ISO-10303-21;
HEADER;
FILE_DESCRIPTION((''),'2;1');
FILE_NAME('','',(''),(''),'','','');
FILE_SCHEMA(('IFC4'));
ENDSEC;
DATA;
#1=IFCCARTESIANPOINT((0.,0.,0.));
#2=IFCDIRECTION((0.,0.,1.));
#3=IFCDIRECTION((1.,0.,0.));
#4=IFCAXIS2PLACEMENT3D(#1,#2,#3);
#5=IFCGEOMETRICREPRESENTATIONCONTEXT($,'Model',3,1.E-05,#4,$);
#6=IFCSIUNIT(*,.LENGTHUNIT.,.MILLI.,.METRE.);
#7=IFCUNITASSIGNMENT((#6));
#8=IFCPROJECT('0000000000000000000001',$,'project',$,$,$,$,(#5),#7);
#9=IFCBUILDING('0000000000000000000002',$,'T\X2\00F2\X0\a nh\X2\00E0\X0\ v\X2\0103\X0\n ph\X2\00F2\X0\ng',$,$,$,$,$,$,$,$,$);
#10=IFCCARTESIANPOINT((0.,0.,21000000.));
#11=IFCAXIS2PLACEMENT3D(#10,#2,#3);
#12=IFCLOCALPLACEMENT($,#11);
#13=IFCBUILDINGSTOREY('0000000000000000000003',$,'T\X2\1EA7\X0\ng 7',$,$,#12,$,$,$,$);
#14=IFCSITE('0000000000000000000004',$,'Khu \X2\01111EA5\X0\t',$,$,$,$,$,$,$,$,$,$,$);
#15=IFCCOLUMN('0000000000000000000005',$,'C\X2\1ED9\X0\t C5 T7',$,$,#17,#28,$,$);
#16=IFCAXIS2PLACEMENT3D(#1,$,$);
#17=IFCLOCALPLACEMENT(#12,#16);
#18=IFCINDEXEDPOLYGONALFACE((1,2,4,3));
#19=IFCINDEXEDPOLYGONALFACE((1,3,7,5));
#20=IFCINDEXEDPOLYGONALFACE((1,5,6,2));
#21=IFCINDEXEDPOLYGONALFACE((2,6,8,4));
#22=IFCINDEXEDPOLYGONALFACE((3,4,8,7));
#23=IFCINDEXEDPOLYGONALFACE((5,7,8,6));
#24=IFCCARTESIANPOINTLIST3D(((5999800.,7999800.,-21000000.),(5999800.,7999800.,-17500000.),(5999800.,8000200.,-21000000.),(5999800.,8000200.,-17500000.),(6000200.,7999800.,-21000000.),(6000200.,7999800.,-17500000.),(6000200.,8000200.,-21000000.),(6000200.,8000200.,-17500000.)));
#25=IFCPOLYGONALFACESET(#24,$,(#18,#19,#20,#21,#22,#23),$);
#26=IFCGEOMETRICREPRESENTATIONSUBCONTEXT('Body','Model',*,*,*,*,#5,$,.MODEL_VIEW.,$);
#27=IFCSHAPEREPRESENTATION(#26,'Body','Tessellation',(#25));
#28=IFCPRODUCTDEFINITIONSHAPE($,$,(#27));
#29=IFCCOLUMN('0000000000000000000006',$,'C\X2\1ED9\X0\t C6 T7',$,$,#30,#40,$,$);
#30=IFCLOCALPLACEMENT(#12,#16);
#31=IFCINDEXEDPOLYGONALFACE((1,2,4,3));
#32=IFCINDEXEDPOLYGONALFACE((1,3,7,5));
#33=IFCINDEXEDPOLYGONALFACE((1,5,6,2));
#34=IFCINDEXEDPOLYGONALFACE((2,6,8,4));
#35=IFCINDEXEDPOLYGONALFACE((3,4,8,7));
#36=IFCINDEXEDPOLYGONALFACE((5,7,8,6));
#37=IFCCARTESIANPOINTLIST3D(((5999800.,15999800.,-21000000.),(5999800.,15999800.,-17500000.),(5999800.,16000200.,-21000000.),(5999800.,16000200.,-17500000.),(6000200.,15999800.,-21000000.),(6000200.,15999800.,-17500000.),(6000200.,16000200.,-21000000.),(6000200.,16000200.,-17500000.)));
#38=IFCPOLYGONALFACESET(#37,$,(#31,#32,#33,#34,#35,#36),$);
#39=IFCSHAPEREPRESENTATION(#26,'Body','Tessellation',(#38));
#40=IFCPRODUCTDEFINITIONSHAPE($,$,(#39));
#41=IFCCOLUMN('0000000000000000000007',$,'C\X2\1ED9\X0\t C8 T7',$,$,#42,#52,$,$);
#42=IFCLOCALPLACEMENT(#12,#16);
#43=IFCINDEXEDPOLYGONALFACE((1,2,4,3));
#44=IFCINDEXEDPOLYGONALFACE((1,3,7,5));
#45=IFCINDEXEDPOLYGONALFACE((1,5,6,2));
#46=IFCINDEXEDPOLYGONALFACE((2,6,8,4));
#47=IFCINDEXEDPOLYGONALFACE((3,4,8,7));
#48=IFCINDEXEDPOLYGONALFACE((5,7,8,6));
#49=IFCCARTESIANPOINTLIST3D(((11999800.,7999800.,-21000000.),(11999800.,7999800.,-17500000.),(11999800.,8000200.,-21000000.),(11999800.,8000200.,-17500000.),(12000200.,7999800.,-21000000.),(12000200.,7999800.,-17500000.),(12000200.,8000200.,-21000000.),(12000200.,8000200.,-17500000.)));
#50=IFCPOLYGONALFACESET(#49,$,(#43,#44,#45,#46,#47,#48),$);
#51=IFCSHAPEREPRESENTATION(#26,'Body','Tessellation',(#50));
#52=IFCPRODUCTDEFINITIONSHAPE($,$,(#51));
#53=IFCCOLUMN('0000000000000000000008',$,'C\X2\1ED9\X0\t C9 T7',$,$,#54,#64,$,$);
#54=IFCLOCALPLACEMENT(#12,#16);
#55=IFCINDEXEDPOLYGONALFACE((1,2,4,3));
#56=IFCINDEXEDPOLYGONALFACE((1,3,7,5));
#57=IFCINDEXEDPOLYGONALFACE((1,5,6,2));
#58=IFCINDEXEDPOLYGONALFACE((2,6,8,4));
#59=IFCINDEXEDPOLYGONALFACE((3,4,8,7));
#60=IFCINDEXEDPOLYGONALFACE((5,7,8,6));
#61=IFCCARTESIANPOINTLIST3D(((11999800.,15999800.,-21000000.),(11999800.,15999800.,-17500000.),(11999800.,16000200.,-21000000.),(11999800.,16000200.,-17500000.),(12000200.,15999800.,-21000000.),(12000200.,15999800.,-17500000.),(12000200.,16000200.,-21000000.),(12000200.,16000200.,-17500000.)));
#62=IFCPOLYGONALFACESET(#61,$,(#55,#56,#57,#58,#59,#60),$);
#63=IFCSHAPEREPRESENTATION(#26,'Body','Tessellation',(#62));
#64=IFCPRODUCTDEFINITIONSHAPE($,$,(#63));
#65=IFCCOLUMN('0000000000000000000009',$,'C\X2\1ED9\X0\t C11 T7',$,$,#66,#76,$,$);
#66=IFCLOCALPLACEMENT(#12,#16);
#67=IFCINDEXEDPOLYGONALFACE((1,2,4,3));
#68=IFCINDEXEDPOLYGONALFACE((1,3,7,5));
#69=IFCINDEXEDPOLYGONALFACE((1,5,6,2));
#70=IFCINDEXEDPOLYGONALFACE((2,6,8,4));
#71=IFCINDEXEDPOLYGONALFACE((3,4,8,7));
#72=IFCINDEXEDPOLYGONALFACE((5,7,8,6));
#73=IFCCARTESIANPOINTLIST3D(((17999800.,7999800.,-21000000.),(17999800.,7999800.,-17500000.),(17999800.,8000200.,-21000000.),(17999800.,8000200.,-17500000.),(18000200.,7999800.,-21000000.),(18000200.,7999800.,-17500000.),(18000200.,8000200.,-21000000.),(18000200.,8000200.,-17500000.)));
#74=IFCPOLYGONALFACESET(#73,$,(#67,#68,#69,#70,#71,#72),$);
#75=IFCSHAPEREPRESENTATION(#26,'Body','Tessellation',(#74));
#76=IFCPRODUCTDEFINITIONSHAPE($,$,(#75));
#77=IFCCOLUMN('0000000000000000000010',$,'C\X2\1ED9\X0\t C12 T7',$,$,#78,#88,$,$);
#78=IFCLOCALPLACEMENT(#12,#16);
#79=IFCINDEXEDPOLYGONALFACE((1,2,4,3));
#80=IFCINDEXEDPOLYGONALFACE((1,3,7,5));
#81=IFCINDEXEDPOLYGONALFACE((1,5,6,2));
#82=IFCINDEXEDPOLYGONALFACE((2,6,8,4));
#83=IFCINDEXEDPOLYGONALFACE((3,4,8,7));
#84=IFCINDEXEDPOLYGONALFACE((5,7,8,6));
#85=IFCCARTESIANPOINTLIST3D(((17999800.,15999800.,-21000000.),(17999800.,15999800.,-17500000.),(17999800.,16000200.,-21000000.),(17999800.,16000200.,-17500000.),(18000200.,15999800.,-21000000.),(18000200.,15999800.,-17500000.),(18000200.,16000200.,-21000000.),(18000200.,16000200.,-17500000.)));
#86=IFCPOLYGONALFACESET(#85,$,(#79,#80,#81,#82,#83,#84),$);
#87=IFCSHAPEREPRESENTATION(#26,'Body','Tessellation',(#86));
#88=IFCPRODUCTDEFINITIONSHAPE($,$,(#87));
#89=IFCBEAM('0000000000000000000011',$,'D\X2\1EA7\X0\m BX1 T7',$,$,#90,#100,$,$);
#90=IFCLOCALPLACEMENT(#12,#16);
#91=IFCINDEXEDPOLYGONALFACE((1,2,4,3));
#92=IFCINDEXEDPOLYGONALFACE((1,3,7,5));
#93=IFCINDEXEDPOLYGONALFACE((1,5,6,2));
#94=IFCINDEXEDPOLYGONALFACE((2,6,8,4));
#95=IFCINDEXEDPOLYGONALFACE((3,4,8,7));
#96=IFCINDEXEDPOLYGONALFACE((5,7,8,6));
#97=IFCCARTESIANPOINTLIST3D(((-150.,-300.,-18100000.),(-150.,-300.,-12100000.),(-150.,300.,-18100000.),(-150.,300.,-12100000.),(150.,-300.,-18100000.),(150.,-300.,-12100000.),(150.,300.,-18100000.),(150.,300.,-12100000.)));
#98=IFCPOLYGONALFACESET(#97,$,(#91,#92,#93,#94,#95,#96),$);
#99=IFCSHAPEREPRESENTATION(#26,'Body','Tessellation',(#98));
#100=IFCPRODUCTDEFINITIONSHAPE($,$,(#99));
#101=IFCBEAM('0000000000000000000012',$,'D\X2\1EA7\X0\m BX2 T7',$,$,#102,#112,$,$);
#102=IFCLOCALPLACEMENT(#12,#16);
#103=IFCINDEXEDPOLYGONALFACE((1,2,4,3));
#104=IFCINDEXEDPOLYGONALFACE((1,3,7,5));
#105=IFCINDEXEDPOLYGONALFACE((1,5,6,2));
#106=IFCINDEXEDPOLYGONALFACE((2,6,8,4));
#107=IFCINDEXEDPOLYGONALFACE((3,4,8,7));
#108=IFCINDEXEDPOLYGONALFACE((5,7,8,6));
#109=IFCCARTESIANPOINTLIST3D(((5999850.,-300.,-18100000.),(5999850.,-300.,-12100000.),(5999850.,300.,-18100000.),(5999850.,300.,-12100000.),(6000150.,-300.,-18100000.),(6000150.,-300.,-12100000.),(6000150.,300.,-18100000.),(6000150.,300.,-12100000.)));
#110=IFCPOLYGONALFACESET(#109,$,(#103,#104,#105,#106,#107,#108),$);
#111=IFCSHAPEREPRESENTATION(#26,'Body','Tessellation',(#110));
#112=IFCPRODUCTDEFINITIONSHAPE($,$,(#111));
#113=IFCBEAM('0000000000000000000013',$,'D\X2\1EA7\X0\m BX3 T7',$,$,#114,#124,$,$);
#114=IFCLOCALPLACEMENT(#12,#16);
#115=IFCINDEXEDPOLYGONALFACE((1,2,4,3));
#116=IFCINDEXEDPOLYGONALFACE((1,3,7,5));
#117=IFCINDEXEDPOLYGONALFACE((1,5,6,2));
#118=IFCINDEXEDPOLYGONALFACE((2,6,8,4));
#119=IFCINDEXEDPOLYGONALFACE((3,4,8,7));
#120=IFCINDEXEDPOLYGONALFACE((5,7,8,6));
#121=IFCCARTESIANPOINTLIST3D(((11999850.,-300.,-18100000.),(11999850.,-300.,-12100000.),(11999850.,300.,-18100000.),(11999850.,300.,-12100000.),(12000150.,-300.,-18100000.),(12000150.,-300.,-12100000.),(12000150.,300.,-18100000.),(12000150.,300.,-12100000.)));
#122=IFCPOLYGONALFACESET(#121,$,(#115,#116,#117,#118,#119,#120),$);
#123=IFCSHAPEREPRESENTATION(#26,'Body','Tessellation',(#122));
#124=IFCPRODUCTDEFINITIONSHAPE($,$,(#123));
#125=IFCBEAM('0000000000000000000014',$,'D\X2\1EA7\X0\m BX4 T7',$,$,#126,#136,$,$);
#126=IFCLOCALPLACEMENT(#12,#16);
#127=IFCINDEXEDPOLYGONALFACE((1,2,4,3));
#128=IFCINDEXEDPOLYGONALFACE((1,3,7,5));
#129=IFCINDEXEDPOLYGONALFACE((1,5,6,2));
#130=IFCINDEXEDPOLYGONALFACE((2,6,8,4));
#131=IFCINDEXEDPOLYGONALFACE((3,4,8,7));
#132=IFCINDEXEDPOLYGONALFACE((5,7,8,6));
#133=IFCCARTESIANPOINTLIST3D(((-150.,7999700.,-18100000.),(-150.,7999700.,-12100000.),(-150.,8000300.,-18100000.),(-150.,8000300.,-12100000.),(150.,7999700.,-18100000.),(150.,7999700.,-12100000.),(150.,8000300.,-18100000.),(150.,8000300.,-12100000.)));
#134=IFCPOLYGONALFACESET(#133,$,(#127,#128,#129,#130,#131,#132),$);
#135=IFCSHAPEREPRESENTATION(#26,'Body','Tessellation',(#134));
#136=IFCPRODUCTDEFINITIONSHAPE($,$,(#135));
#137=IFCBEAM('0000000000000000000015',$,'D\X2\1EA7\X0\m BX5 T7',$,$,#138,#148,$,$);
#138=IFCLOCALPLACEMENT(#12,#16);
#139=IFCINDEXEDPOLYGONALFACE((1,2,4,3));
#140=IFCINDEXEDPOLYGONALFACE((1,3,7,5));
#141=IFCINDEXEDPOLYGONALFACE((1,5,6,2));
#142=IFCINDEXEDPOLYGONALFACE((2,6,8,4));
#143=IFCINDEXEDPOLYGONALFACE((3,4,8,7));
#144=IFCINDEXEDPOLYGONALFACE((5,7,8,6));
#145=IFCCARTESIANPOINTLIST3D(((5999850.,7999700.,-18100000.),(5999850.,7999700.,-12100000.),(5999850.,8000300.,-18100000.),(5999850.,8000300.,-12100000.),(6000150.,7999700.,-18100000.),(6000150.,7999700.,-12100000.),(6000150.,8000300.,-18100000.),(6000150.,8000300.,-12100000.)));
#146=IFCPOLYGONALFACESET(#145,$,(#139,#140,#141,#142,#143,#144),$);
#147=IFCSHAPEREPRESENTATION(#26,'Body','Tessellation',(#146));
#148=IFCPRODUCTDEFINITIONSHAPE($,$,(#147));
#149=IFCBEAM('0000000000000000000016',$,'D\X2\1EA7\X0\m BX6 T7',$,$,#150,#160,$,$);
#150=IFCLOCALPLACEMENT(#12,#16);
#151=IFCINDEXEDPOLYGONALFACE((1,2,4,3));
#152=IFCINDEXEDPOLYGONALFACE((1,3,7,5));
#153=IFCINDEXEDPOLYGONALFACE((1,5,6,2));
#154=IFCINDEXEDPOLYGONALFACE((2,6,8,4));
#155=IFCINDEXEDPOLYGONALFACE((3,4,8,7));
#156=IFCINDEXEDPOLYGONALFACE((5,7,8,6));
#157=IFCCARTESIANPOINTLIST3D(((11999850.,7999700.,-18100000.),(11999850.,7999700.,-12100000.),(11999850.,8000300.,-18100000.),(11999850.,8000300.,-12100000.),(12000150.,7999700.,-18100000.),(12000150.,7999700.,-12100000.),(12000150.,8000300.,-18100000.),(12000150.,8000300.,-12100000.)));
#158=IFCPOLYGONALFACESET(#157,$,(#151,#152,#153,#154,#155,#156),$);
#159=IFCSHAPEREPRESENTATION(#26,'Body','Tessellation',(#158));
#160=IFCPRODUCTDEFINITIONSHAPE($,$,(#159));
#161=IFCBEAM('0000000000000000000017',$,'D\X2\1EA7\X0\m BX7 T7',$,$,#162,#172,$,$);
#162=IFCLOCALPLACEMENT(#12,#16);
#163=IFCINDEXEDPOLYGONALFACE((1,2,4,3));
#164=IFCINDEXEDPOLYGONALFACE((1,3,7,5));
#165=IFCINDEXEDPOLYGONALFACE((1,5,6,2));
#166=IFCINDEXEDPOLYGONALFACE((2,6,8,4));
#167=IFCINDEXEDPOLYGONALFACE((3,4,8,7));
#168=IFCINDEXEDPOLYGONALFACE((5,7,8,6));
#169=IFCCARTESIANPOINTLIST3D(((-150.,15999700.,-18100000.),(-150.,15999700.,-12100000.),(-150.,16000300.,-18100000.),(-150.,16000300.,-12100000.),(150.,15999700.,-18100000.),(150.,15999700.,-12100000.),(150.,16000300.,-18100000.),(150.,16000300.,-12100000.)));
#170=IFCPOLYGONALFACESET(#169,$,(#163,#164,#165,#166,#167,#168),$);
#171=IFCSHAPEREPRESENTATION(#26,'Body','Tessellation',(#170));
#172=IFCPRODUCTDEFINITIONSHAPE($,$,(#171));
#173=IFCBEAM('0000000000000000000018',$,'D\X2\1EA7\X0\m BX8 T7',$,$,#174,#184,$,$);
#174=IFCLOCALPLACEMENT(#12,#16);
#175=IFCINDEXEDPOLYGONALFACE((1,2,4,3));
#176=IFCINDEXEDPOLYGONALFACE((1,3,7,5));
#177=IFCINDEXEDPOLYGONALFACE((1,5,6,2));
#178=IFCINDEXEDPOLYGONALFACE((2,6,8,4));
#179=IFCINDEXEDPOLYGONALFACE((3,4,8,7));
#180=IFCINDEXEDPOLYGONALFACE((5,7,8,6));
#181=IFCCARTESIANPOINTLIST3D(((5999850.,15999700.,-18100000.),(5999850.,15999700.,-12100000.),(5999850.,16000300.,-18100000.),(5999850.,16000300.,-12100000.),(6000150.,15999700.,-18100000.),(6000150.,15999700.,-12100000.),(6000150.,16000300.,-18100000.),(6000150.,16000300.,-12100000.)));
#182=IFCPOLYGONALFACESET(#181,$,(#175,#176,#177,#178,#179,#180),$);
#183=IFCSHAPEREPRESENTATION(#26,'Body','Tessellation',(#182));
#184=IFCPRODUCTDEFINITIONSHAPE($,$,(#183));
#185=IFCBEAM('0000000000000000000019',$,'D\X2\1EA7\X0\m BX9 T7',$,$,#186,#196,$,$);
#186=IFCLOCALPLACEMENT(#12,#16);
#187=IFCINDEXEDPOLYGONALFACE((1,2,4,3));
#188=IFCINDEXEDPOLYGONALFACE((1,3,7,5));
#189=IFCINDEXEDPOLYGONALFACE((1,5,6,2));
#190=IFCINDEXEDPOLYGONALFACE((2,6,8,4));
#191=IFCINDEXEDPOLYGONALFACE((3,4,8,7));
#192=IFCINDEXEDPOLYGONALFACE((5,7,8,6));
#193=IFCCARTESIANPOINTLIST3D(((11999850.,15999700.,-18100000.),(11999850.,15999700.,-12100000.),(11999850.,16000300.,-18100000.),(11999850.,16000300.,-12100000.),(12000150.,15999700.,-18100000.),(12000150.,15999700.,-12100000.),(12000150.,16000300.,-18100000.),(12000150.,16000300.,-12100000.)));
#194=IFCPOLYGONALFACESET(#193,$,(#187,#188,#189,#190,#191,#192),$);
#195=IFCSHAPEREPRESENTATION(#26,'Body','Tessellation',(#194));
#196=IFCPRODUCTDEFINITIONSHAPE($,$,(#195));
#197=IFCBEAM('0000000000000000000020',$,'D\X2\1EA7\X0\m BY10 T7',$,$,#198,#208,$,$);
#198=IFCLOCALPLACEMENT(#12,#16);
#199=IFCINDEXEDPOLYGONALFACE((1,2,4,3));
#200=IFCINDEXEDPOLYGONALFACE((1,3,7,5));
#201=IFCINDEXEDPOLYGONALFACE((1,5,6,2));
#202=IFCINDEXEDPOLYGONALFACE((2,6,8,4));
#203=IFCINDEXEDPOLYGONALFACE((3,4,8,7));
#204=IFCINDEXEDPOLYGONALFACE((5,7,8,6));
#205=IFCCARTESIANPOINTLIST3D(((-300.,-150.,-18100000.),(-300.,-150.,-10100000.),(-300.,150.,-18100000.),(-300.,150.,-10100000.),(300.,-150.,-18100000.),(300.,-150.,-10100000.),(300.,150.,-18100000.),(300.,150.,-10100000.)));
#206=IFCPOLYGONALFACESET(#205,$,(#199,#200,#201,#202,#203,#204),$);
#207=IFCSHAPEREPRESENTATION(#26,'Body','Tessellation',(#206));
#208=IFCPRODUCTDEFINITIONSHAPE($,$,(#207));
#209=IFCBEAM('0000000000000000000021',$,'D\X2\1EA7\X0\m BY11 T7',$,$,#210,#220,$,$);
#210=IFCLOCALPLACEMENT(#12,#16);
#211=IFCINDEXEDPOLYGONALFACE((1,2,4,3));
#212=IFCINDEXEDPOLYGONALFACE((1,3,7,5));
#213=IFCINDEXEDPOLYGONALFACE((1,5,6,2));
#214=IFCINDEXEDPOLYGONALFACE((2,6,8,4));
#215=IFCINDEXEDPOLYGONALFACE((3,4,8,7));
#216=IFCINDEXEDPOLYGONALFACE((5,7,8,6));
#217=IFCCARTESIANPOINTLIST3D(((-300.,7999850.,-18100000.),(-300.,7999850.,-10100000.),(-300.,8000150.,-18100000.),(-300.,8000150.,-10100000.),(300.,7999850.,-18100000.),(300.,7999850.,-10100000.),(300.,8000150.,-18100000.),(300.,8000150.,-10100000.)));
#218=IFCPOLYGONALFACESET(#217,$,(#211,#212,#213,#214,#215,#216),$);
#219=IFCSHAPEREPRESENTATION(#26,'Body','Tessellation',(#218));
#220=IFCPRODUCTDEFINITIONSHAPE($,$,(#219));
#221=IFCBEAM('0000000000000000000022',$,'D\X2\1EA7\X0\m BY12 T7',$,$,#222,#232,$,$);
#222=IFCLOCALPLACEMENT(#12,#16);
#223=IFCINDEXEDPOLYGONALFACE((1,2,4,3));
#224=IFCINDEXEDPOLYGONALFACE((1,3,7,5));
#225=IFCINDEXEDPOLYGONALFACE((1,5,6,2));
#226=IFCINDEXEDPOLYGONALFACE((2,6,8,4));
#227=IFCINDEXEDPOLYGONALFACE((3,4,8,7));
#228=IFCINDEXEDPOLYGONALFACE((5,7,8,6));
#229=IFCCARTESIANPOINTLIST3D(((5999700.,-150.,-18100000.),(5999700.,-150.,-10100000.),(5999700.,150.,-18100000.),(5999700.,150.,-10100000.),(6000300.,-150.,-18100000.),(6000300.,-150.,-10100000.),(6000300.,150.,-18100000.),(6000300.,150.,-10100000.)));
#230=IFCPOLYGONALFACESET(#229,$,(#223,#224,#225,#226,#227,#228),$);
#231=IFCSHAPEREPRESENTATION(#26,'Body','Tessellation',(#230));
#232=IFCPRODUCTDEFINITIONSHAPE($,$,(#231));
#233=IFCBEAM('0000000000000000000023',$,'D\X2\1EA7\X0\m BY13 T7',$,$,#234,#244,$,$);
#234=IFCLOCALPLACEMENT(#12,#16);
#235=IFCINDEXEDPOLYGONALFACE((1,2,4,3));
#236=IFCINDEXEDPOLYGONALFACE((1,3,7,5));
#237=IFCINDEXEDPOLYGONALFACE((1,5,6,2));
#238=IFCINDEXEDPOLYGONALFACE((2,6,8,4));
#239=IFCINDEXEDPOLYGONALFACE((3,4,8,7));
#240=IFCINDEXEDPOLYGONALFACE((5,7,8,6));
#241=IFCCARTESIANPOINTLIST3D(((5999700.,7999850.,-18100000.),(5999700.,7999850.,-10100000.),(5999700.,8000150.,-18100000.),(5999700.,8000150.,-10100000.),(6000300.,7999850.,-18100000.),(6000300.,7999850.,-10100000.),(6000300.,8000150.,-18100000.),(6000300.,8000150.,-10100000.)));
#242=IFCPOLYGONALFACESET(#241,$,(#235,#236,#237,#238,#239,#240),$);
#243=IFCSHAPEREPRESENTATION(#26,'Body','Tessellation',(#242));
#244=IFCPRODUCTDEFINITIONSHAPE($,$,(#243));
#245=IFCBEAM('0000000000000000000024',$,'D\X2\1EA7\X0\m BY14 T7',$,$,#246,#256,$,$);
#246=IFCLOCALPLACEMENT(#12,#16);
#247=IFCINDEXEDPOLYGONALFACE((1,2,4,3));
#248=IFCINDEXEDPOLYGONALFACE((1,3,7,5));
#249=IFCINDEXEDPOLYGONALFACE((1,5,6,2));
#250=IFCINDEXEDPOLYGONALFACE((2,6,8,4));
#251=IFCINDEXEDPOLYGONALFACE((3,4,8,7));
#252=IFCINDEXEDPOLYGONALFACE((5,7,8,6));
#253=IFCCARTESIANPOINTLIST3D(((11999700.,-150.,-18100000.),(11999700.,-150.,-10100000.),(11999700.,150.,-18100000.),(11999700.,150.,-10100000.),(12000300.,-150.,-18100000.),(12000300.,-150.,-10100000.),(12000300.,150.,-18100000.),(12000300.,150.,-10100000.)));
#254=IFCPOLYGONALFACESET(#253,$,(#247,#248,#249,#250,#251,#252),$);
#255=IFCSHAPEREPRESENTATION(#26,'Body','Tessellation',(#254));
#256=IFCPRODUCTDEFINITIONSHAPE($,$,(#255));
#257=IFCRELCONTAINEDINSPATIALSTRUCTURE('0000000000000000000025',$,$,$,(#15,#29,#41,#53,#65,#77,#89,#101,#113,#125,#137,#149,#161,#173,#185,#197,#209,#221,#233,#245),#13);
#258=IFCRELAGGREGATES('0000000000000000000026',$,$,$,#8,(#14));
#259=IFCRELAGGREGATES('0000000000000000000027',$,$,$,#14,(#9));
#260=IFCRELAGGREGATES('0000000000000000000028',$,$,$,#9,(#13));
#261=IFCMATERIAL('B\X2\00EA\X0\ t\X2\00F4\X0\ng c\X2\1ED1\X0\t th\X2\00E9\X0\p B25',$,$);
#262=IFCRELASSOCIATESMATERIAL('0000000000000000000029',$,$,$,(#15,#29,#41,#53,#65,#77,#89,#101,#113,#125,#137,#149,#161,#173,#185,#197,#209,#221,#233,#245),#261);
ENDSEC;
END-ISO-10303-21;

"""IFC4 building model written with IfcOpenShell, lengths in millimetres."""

from ifc_helpers import new_model, entity, si_unit, frame, origin_with_axes, place, context, subcontext, project, spatial, extrude, material, element, save


model = new_model("IFC4")

# Units and contexts
model_context = context("Model", 3, precision=1e-05, world=origin_with_axes())
body_context = subcontext(model_context, "Body", "Model", "MODEL_VIEW")
ifc_project = project(units=[si_unit("LENGTHUNIT", "METRE", prefix="MILLI")], contexts=[model_context])

# Site, building, storey
site = spatial("IfcSite", under=ifc_project, Name="Khu đất")
building = spatial("IfcBuilding", under=site, Name="Tòa nhà văn phòng")
storey_placement = place(None, frame((0.0, 0.0, 21000000.0), z_axis=(0.0, 0.0, 1.0), x_axis=(1.0, 0.0, 0.0)))
storey = spatial("IfcBuildingStorey", under=building, at=storey_placement, Name="Tầng 7")

# Columns
ifc_material_1 = material(Name="Bê tông cốt thép B25")
for number, where, z_axis, x_axis, name in (
    (1, (6000000.0, 8000000.0, -21000000.0), (0.0, 0.0, 1.0), (1.0, 0.0, 0.0), "Cột C5 T7"),
    (2, (6000000.0, 16000000.0, -21000000.0), (0.0, 0.0, 1.0), (1.0, 0.0, 0.0), "Cột C6 T7"),
    (3, (12000000.0, 8000000.0, -21000000.0), (0.0, 0.0, 1.0), (1.0, 0.0, 0.0), "Cột C8 T7"),
    (4, (12000000.0, 16000000.0, -21000000.0), (0.0, 0.0, 1.0), (1.0, 0.0, 0.0), "Cột C9 T7"),
    (5, (18000000.0, 8000000.0, -21000000.0), (0.0, 0.0, 1.0), (1.0, 0.0, 0.0), "Cột C11 T7"),
    (6, (18000000.0, 16000000.0, -21000000.0), (0.0, 0.0, 1.0), (1.0, 0.0, 0.0), "Cột C12 T7"),
):
    element("IfcColumn", number, at=place(storey_placement, frame(where, z_axis=z_axis, x_axis=x_axis)), inside=storey, material=ifc_material_1, Name=name, context=body_context, shape_type="SweptSolid", body=[
        extrude(entity("IfcRectangleProfileDef", None, None, None, 400.0, 400.0), origin_with_axes(), (0.0, 0.0, 1.0), 3500000.0),
    ])

# Beams
for number, where, z_axis, x_axis, name in (
    (7, (0.0, 0.0, -18100000.0), (0.0, 0.0, 1.0), (1.0, 0.0, 0.0), "Dầm BX1 T7"),
    (8, (6000000.0, 0.0, -18100000.0), (0.0, 0.0, 1.0), (1.0, 0.0, 0.0), "Dầm BX2 T7"),
    (9, (12000000.0, 0.0, -18100000.0), (0.0, 0.0, 1.0), (1.0, 0.0, 0.0), "Dầm BX3 T7"),
    (10, (0.0, 8000000.0, -18100000.0), (0.0, 0.0, 1.0), (1.0, 0.0, 0.0), "Dầm BX4 T7"),
    (11, (6000000.0, 8000000.0, -18100000.0), (0.0, 0.0, 1.0), (1.0, 0.0, 0.0), "Dầm BX5 T7"),
    (12, (12000000.0, 8000000.0, -18100000.0), (0.0, 0.0, 1.0), (1.0, 0.0, 0.0), "Dầm BX6 T7"),
    (13, (0.0, 16000000.0, -18100000.0), (0.0, 0.0, 1.0), (1.0, 0.0, 0.0), "Dầm BX7 T7"),
    (14, (6000000.0, 16000000.0, -18100000.0), (0.0, 0.0, 1.0), (1.0, 0.0, 0.0), "Dầm BX8 T7"),
    (15, (12000000.0, 16000000.0, -18100000.0), (0.0, 0.0, 1.0), (1.0, 0.0, 0.0), "Dầm BX9 T7"),
):
    element("IfcBeam", number, at=place(storey_placement, frame(where, z_axis=z_axis, x_axis=x_axis)), inside=storey, material=ifc_material_1, Name=name, context=body_context, shape_type="SweptSolid", body=[
        extrude(entity("IfcRectangleProfileDef", None, None, None, 300.0, 600.0), origin_with_axes(), (0.0, 0.0, 1.0), 6000000.0),
    ])
for number, where, z_axis, x_axis, name in (
    (16, (0.0, 0.0, -18100000.0), (0.0, 0.0, 1.0), (0.0, 1.0, 0.0), "Dầm BY10 T7"),
    (17, (0.0, 8000000.0, -18100000.0), (0.0, 0.0, 1.0), (0.0, 1.0, 0.0), "Dầm BY11 T7"),
    (18, (6000000.0, 0.0, -18100000.0), (0.0, 0.0, 1.0), (0.0, 1.0, 0.0), "Dầm BY12 T7"),
    (19, (6000000.0, 8000000.0, -18100000.0), (0.0, 0.0, 1.0), (0.0, 1.0, 0.0), "Dầm BY13 T7"),
    (20, (12000000.0, 0.0, -18100000.0), (0.0, 0.0, 1.0), (0.0, 1.0, 0.0), "Dầm BY14 T7"),
):
    element("IfcBeam", number, at=place(storey_placement, frame(where, z_axis=z_axis, x_axis=x_axis)), inside=storey, material=ifc_material_1, Name=name, context=body_context, shape_type="SweptSolid", body=[
        extrude(entity("IfcRectangleProfileDef", None, None, None, 300.0, 600.0), origin_with_axes(), (0.0, 0.0, 1.0), 8000000.0),
    ])

save(model, "model.ifc")
